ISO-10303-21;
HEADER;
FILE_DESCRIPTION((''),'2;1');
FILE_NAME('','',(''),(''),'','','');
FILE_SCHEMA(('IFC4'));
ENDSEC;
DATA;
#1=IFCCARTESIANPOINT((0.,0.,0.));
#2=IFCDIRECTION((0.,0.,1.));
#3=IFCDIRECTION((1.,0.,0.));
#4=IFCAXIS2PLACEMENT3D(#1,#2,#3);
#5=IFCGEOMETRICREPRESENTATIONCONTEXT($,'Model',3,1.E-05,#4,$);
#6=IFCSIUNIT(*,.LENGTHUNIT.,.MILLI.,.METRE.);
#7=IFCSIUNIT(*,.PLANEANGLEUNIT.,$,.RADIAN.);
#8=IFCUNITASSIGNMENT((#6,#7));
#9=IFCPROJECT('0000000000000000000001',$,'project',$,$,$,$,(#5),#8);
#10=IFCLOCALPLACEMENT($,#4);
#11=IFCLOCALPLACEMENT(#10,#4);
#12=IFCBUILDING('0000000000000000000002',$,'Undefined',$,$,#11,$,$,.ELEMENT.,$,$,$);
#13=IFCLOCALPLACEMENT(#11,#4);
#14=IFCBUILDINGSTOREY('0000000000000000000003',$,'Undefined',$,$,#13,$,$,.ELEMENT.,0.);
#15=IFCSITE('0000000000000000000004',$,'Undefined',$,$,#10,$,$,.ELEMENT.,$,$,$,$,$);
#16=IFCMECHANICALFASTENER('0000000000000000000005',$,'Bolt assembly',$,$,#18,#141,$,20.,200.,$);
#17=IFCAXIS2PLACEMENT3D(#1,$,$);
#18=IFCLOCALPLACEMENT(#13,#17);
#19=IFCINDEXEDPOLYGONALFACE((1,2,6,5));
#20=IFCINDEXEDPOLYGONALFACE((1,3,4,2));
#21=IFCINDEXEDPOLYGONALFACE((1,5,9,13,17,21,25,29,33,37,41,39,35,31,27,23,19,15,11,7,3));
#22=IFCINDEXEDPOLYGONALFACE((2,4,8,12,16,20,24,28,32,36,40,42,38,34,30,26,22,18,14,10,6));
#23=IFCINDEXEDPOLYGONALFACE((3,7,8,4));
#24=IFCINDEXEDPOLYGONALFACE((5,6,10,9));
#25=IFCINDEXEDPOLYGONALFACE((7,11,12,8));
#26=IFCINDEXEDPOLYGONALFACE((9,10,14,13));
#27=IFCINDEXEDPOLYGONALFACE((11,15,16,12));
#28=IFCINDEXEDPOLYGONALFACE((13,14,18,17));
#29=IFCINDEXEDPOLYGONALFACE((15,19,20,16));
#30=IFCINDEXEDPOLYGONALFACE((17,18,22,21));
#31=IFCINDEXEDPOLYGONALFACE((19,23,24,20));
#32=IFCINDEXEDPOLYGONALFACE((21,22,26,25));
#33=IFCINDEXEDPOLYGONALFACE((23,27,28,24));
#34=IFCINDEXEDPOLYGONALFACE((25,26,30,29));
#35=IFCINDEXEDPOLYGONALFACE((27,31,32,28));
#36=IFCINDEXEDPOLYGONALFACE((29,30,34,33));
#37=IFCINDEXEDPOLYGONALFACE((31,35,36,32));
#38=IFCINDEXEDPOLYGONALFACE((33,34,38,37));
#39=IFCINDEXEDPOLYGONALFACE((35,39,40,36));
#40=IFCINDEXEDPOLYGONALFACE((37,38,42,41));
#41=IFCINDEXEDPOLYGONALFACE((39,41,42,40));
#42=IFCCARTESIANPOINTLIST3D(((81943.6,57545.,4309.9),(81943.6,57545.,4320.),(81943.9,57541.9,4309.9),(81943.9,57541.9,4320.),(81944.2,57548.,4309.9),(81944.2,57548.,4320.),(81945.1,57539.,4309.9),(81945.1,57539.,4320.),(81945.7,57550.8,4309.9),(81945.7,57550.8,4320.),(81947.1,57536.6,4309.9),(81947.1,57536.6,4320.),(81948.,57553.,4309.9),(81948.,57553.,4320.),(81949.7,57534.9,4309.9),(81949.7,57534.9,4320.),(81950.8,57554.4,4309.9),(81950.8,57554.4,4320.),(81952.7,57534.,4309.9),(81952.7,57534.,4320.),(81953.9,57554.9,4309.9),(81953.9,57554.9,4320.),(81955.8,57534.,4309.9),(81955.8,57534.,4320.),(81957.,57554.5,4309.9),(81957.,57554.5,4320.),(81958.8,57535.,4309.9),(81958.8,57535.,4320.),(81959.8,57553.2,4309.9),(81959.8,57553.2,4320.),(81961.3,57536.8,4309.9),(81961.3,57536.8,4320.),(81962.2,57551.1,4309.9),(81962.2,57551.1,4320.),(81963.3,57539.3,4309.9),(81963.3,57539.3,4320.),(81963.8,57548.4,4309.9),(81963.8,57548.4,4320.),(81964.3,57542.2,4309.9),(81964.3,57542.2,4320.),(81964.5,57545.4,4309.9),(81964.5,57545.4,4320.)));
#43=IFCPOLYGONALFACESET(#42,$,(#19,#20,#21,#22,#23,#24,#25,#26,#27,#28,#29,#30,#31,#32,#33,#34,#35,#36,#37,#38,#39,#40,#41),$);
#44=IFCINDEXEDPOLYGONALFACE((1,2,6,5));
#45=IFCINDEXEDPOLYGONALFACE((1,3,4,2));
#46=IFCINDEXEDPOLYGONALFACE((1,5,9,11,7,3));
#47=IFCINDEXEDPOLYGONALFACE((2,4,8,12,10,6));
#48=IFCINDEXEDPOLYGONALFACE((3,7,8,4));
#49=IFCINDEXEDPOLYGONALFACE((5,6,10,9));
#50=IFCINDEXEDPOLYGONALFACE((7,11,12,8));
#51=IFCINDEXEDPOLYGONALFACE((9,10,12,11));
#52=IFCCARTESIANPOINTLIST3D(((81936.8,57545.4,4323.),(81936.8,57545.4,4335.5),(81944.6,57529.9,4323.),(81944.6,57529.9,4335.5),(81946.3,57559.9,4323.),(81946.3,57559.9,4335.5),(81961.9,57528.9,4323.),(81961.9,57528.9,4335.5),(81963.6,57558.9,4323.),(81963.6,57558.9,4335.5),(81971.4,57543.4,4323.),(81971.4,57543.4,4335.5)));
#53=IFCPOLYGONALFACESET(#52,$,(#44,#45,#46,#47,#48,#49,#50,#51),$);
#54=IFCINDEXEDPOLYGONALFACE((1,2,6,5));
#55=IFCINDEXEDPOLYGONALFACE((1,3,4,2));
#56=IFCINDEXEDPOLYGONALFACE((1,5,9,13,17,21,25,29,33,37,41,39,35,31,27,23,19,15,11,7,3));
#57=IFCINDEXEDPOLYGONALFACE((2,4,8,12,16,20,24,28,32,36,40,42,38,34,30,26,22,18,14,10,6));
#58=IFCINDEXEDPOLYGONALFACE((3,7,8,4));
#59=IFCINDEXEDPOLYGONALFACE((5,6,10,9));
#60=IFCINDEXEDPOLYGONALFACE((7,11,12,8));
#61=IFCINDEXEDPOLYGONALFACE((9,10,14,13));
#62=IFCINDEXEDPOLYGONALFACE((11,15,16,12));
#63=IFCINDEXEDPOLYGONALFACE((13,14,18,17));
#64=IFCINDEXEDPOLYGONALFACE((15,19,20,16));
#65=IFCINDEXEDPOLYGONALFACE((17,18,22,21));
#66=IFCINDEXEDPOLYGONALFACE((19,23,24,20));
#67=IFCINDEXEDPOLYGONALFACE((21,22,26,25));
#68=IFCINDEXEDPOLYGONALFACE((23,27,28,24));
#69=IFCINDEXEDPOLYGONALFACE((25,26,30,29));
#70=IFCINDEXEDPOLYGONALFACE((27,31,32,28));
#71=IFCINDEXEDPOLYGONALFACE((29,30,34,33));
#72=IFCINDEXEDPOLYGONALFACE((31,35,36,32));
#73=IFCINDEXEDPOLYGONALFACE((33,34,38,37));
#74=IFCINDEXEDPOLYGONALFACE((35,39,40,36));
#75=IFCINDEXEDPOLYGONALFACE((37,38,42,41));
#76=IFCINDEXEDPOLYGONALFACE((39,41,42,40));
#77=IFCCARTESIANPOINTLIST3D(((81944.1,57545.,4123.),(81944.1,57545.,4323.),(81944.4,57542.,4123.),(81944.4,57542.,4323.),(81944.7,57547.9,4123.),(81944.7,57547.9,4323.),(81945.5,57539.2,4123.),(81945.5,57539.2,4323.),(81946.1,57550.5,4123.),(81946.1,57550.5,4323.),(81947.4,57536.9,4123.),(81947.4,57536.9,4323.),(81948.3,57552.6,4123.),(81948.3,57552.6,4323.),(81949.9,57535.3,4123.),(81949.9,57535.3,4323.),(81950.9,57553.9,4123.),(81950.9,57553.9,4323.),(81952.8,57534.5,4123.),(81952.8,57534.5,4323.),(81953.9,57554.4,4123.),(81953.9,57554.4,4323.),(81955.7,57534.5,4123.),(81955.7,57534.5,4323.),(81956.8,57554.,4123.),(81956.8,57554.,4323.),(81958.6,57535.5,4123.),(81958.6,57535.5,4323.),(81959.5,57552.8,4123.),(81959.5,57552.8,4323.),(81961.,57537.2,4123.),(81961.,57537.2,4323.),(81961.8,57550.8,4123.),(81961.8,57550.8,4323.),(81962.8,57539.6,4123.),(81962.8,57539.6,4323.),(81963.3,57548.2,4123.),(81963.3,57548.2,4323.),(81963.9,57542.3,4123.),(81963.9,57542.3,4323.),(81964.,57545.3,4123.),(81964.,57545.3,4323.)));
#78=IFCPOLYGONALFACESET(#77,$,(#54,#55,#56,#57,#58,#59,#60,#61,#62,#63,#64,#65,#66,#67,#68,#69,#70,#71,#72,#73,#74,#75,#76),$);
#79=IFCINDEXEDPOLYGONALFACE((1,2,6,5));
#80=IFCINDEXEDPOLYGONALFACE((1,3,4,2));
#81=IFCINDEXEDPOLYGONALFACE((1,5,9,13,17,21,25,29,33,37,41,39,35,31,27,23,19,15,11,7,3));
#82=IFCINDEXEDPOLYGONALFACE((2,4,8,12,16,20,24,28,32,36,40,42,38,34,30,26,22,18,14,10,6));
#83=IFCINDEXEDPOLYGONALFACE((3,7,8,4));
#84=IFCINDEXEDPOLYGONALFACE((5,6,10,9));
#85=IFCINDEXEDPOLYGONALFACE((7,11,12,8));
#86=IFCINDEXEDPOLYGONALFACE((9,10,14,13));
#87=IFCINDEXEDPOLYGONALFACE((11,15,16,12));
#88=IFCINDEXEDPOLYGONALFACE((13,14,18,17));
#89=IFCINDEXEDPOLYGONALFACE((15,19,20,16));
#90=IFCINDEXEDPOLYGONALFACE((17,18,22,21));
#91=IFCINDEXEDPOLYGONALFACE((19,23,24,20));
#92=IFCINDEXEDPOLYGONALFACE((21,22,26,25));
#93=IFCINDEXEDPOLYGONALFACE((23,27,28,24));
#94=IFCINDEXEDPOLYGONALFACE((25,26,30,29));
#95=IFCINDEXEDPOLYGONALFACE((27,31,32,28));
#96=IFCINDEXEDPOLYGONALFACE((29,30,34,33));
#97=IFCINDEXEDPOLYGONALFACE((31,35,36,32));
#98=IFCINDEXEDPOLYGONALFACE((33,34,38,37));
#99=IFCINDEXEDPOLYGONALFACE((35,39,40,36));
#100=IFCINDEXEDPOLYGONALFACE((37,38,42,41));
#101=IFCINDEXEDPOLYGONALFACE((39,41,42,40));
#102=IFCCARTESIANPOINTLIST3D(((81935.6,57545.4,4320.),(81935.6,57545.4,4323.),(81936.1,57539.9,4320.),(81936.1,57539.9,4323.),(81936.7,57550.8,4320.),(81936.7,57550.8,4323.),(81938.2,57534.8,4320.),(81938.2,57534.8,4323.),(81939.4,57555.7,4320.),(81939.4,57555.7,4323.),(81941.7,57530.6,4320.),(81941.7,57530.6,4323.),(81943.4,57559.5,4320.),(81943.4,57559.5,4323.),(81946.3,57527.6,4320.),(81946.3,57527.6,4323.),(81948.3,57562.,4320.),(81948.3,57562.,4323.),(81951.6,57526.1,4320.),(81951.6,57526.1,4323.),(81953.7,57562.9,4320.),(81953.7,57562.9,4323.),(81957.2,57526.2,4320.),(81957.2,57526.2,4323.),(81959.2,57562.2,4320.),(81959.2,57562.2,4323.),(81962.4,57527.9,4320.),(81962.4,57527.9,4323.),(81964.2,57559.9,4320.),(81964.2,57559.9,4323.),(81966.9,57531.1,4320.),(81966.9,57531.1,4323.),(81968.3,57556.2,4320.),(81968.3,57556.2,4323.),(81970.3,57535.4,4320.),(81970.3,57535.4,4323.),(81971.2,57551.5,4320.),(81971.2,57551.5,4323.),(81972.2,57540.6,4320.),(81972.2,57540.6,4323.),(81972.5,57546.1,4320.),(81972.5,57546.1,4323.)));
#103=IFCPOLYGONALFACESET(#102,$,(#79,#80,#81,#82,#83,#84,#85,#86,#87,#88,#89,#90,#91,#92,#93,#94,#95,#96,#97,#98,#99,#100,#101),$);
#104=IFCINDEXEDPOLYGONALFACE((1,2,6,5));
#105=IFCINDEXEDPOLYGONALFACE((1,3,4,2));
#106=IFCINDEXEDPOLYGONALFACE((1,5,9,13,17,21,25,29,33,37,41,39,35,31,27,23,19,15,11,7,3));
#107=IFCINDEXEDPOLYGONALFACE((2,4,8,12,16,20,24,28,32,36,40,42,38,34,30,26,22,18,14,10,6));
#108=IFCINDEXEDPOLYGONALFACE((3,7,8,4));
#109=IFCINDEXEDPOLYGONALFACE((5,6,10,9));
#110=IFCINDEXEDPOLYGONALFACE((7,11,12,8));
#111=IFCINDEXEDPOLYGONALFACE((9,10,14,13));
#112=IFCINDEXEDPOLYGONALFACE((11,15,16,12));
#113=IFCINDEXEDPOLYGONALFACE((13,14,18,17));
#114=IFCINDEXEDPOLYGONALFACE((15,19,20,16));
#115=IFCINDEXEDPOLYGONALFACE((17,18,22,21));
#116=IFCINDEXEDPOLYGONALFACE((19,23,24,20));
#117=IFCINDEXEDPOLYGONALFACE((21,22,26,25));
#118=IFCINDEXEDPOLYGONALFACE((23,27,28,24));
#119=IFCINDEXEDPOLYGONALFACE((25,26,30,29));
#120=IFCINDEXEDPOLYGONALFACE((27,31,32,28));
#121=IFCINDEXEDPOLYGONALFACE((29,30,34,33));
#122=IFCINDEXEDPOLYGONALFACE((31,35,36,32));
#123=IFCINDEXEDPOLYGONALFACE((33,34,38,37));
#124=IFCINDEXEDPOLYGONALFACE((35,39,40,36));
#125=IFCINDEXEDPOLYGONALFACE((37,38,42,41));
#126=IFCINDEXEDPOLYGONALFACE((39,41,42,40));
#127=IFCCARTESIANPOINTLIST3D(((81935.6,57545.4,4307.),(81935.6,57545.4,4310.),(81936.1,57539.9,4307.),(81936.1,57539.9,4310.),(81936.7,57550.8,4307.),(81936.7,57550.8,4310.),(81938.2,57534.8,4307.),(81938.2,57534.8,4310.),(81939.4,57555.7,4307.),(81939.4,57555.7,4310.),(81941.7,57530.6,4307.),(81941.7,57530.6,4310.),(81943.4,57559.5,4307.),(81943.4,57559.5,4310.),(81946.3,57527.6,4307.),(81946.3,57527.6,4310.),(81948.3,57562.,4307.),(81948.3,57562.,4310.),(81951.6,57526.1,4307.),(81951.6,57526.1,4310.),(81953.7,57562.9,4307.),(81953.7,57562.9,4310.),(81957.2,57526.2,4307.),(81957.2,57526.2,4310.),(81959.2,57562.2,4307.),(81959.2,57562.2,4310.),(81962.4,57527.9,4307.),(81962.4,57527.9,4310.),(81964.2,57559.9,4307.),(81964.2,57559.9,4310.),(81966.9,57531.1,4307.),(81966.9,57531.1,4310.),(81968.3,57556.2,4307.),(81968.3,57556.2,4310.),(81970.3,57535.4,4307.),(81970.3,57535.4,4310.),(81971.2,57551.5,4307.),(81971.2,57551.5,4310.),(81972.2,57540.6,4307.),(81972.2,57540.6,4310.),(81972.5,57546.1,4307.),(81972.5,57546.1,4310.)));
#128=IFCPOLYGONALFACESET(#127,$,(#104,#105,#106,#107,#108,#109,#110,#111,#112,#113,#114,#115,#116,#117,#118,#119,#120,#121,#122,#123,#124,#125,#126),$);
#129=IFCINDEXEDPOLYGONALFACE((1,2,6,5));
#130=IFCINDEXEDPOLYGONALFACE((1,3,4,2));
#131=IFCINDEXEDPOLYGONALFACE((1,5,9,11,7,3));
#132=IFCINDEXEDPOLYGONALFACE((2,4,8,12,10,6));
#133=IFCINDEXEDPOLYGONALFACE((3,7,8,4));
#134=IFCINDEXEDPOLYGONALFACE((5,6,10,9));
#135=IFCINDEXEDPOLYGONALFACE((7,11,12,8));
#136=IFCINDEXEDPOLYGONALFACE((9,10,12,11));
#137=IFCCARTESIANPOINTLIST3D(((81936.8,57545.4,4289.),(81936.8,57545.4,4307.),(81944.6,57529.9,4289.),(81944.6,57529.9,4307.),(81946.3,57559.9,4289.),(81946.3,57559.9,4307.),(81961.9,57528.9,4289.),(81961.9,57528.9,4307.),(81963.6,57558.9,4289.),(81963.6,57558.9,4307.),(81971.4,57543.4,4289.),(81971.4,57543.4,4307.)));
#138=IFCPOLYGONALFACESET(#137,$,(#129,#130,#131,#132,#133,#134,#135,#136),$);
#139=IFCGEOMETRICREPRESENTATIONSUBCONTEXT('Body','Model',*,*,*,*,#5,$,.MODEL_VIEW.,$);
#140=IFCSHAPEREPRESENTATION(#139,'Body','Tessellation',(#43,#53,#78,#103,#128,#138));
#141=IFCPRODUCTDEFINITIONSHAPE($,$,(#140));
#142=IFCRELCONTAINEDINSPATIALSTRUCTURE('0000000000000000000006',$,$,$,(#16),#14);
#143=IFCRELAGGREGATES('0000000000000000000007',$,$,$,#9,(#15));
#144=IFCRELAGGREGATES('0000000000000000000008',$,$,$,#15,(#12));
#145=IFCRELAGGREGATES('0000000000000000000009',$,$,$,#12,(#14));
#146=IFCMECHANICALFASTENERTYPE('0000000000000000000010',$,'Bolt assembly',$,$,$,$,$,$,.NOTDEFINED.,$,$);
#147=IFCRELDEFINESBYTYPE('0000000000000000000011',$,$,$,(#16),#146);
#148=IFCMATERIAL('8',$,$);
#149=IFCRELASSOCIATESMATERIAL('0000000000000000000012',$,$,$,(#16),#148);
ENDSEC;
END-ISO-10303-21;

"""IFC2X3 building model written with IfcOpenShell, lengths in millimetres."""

from ifc_helpers import new_model, si_unit, frame, origin_with_axes, origin_2d_with_axis, place, context, subcontext, project, spatial, polyline, circle, outline, extrude, source, transform, mapped, material, type_object, element, save


model = new_model("IFC2X3")

# Units and contexts
model_context = context("Model", 3, precision=1e-05, world=origin_with_axes())
body_context = subcontext(model_context, "Body", "Model", "MODEL_VIEW")
ifc_project = project(units=[si_unit("LENGTHUNIT", "METRE", prefix="MILLI"), si_unit("PLANEANGLEUNIT", "RADIAN")], contexts=[model_context])

# Site, building, storey
site_placement = place(None, origin_with_axes())
site = spatial("IfcSite", under=ifc_project, at=site_placement, Name="Undefined", CompositionType="ELEMENT")
building_placement = place(site_placement, origin_with_axes())
building = spatial("IfcBuilding", under=site, at=building_placement, Name="Undefined", CompositionType="ELEMENT")
storey_placement = place(building_placement, origin_with_axes())
storey = spatial("IfcBuildingStorey", under=building, at=storey_placement, Name="Undefined", CompositionType="ELEMENT", Elevation=0.0)

# Mechanical fastener
ifc_material_1 = material(Name="8")
mechanical_fastener_type = type_object("IfcMechanicalFastenerType", Name="Bolt assembly")
shared_shape_1 = source(origin_with_axes(), body_context, "Body", "SweptSolid", [
    extrude(circle(Radius=10.5, at=origin_2d_with_axis()), frame((0.0, 0.0, 0.0), z_axis=(0.0, 1.0, 0.0), x_axis=(1.0, 0.0, 0.0)), (0.0, 0.0, 1.0), 10.1),
    extrude(outline(polyline([(17.3, 0.0), (8.7, 15.0), (-8.7, 15.0), (-17.3, 0.0), (-8.7, -15.0), (8.7, -15.0), (17.3, 0.0)])), frame((0.0, -15.5, 0.0), z_axis=(0.0, 1.0, 0.0), x_axis=(1.0, 0.0, 0.0)), (0.0, 0.0, 1.0), 12.5),
    extrude(circle(Radius=10.0, at=origin_2d_with_axis()), frame((0.0, -3.0, 0.0), z_axis=(0.0, 1.0, 0.0), x_axis=(1.0, 0.0, 0.0)), (0.0, 0.0, 1.0), 200.0),
    extrude(circle(Radius=18.5, at=origin_2d_with_axis()), frame((0.0, -3.0, 0.0), z_axis=(0.0, 1.0, 0.0), x_axis=(1.0, 0.0, 0.0)), (0.0, 0.0, 1.0), 3.0),
    extrude(circle(Radius=18.5, at=origin_2d_with_axis()), frame((0.0, 10.0, 0.0), z_axis=(0.0, 1.0, 0.0), x_axis=(1.0, 0.0, 0.0)), (0.0, 0.0, 1.0), 3.0),
    extrude(outline(polyline([(17.3, 0.0), (8.7, 15.0), (-8.7, 15.0), (-17.3, 0.0), (-8.7, -15.0), (8.7, -15.0), (17.3, 0.0)])), frame((0.0, 13.0, 0.0), z_axis=(0.0, 1.0, 0.0), x_axis=(1.0, 0.0, 0.0)), (0.0, 0.0, 1.0), 18.0),
])
for number, where, z_axis, x_axis, name in (
    (1, (81954.1, 57544.4, 4320.0), (0.892799, 0.450455, 0.0), (0.450455, -0.892799, 0.0), "Bolt assembly"),
):
    element("IfcMechanicalFastener", number, at=place(storey_placement, frame(where, z_axis=z_axis, x_axis=x_axis)), inside=storey, type_object=mechanical_fastener_type, material=ifc_material_1, Name=name, NominalDiameter=20.0, NominalLength=200.0, context=body_context, shape_type="MappedRepresentation", body=[
        mapped(shared_shape_1, transform((0.0, 0.0, 0.0))),
    ])

save(model, "model.ifc")
